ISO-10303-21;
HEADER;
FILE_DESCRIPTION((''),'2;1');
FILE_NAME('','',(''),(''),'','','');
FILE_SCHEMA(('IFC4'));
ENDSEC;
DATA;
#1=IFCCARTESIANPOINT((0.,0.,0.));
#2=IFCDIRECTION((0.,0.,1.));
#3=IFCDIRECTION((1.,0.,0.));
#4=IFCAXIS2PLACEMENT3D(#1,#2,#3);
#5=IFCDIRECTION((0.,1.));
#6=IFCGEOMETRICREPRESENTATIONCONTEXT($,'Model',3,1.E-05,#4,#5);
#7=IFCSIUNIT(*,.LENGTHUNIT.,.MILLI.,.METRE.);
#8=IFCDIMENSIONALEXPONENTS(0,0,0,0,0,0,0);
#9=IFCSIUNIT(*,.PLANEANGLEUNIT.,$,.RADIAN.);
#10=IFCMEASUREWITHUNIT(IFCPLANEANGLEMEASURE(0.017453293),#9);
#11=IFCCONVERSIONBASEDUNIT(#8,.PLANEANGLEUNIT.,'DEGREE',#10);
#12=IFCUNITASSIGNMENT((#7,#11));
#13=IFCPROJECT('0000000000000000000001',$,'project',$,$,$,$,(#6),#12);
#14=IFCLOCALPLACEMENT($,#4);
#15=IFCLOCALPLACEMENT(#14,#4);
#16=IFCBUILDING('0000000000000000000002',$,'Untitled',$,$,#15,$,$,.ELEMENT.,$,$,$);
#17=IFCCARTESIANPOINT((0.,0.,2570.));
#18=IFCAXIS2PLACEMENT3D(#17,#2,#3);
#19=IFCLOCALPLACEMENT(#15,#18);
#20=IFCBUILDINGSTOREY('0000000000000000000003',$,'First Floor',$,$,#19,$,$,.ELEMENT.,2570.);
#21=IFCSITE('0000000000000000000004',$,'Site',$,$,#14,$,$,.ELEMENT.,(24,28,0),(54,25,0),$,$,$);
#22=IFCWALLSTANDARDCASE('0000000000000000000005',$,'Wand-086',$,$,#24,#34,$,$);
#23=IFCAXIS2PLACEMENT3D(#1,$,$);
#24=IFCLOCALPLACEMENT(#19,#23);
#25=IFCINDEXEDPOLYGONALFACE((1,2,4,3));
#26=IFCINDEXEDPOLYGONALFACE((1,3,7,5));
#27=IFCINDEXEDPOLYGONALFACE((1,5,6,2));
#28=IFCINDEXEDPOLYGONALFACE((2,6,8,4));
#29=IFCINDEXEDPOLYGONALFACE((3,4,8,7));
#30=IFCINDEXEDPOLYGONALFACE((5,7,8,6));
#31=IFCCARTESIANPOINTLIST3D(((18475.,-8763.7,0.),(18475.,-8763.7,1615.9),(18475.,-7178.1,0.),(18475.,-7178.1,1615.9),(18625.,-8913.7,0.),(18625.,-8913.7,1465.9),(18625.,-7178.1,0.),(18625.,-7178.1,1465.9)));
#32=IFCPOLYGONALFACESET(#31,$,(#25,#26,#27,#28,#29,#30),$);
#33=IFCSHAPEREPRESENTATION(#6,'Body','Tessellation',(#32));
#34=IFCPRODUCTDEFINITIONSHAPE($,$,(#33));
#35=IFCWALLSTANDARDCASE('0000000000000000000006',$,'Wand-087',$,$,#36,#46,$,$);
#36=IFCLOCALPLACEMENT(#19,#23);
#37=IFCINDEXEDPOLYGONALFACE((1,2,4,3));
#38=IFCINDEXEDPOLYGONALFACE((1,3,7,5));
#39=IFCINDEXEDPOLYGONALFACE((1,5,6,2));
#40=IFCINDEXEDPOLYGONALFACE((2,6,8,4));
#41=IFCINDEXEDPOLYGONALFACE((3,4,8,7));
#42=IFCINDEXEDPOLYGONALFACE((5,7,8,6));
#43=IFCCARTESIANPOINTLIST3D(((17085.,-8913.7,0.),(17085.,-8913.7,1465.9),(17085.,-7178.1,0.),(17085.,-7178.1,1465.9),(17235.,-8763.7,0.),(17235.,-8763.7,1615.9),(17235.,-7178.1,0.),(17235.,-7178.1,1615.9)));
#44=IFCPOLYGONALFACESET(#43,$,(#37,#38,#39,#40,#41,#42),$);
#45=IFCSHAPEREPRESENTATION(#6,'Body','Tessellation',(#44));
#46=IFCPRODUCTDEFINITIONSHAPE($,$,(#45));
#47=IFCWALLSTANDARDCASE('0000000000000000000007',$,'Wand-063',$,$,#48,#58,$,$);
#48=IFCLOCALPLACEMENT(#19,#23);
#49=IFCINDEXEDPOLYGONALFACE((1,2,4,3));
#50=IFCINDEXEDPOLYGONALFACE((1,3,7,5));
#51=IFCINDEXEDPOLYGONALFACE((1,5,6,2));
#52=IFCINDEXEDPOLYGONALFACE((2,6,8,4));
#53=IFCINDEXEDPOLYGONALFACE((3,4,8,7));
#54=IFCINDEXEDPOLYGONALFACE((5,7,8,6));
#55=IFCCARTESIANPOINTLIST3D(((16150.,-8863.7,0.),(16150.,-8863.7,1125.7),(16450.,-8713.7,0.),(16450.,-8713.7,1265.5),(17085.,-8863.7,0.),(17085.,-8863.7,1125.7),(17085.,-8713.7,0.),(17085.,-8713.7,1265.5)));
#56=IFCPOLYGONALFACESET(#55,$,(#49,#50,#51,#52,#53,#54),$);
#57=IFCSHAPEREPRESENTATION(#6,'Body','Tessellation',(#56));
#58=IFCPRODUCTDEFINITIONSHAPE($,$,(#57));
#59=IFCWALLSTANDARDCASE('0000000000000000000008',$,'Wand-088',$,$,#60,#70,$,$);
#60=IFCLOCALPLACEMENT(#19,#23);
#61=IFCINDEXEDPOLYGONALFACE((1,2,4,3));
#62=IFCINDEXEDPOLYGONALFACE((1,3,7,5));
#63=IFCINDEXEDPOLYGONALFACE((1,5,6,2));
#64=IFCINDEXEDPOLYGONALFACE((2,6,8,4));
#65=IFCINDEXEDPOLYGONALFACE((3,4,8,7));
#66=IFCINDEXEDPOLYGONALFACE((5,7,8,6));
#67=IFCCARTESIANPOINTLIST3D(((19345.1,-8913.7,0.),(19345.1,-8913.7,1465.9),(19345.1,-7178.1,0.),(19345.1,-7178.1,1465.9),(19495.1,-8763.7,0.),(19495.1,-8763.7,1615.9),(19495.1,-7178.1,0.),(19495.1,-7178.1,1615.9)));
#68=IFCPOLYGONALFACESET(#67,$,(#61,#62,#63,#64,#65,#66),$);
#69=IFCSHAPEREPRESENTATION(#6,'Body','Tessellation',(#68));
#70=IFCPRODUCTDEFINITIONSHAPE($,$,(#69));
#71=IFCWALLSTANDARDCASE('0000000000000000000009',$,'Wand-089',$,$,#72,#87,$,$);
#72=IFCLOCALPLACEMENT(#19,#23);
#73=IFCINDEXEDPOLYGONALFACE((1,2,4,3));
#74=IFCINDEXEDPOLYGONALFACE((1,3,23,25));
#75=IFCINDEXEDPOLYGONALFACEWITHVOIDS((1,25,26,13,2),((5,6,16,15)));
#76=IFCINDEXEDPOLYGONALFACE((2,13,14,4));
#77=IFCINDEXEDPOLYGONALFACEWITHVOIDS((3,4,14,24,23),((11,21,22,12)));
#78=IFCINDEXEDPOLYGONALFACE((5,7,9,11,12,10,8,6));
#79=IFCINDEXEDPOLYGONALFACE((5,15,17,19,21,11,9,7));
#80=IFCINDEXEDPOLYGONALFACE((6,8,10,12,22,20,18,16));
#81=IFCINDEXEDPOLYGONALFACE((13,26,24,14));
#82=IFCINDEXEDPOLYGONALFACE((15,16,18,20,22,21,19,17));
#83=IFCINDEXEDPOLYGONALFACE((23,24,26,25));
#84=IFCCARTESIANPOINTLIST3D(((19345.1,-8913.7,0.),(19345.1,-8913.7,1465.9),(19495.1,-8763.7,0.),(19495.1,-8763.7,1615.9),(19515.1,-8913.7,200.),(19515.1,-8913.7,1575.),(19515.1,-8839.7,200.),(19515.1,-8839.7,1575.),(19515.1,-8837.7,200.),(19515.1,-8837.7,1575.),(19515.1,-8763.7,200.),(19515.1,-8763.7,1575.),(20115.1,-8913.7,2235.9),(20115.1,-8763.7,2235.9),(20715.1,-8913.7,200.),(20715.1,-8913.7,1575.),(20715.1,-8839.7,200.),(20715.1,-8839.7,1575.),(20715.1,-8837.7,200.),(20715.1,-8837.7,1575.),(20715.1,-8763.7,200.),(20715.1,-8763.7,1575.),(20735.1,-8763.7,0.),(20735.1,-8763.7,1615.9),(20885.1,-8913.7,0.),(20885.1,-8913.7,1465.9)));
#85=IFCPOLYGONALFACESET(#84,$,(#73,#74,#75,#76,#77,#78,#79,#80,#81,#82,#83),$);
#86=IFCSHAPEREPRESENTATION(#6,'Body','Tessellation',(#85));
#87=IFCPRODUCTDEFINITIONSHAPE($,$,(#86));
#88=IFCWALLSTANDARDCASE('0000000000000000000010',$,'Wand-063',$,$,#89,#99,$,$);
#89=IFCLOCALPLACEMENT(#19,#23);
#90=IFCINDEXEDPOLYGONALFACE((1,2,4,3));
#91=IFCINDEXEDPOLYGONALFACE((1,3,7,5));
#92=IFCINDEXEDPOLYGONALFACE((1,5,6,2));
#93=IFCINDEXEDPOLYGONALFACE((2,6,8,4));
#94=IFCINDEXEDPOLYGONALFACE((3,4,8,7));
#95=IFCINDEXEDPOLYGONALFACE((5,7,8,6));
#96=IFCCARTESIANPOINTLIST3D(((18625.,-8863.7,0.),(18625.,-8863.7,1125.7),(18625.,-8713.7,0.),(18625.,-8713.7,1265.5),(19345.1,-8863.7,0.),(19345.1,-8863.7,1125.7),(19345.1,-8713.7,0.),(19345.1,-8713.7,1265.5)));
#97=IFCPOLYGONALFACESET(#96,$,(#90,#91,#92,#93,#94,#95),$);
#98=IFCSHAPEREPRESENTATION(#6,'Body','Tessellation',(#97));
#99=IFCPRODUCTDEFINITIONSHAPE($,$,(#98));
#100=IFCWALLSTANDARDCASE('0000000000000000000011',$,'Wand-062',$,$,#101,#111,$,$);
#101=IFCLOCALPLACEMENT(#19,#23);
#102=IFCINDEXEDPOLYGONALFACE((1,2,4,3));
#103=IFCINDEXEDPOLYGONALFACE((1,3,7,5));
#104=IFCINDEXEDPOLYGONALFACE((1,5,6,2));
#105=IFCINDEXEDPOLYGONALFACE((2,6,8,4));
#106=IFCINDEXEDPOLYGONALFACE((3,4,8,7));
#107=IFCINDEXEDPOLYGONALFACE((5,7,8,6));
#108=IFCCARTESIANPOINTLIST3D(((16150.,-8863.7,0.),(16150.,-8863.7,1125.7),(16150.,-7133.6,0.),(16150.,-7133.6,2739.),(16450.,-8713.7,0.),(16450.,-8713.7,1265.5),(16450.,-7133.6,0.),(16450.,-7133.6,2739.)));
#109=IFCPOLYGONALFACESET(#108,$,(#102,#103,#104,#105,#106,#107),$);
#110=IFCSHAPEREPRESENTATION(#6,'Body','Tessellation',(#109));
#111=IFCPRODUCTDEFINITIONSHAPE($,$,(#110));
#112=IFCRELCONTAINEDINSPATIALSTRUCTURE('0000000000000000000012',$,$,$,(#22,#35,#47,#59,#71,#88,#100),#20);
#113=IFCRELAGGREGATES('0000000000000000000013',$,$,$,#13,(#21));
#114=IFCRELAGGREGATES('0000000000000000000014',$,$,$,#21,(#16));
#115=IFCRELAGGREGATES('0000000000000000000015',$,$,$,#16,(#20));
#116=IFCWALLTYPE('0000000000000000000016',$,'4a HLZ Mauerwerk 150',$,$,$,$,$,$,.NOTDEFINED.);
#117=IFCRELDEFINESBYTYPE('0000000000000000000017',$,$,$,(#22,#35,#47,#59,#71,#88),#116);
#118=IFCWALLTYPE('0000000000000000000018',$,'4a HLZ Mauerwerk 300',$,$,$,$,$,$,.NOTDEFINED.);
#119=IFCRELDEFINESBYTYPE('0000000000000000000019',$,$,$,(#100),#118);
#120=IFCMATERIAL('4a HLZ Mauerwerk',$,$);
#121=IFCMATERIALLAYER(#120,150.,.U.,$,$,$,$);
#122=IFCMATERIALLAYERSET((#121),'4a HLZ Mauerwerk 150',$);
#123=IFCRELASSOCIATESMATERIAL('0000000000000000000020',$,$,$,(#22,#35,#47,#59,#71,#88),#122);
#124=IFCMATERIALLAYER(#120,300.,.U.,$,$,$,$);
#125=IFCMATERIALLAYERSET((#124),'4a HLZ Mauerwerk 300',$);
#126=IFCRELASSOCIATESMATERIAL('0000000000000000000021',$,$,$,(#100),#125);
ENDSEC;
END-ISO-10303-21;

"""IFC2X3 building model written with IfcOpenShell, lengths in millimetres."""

from ifc_helpers import new_model, entity, si_unit, converted_unit, direction, frame, origin_with_axes, origin_2d_with_axis, place, context, project, spatial, polyline, rectangle, outline, extrude, clip, halfspace, bounded_halfspace, material, layer, layer_set, layer_usage, type_object, element, save


model = new_model("IFC2X3")

# Units and contexts
model_context = context("Model", 3, precision=1e-05, world=origin_with_axes(), true_north=direction((0.0, 1.0)))
ifc_project = project(units=[si_unit("LENGTHUNIT", "METRE", prefix="MILLI"), converted_unit("PLANEANGLEUNIT", "DEGREE", entity("IfcPlaneAngleMeasure", 0.017453293), si_unit("PLANEANGLEUNIT", "RADIAN"), dimensions=[0, 0, 0, 0, 0, 0, 0])], contexts=[model_context])

# Site, building, storey
site_placement = place(None, origin_with_axes())
site = spatial("IfcSite", under=ifc_project, at=site_placement, Name="Site", CompositionType="ELEMENT", RefLatitude=(24, 28, 0), RefLongitude=(54, 25, 0))
building_placement = place(site_placement, origin_with_axes())
building = spatial("IfcBuilding", under=site, at=building_placement, Name="Untitled", CompositionType="ELEMENT")
storey_placement = place(building_placement, frame((0.0, 0.0, 2570.0), z_axis=(0.0, 0.0, 1.0), x_axis=(1.0, 0.0, 0.0)))
storey = spatial("IfcBuildingStorey", under=building, at=storey_placement, Name="First Floor", CompositionType="ELEMENT", Elevation=2570.0)

# Shared definitions
ifc_material_1 = material(Name="4a HLZ Mauerwerk")
ifc_layer_1 = layer(ifc_material_1, 150.0, ventilated="UNKNOWN")
ifc_layer_set_1 = layer_set([ifc_layer_1], Name="4a HLZ Mauerwerk 150")
wall_type_1 = type_object("IfcWallType", Name="4a HLZ Mauerwerk 150", PredefinedType="NOTDEFINED")

# Walls
ifc_layer_usage_1 = layer_usage(ifc_layer_set_1, "AXIS2", "POSITIVE", 0.0)
wall_1_placement = place(storey_placement, frame((18625.0, -8913.7, 0.0), z_axis=(0.0, 0.0, 1.0), x_axis=(0.0, 1.0, 0.0)))
element("IfcWallStandardCase", 1, at=wall_1_placement, inside=storey, type_object=wall_type_1, material=ifc_layer_usage_1, Name="Wand-086", context=model_context, shape_type="Clipping", body=[
    clip(extrude(outline(polyline([(0.0, 0.0), (1735.6, 0.0), (1735.6, 150.0), (150.0, 150.0), (0.0, 0.0)])), origin_with_axes(), (0.0, 0.0, 1.0), 5316.0), halfspace(frame((0.0, -733.0, 733.0), z_axis=(0.0, 0.707107, -0.707107), x_axis=(0.0, -0.707107, -0.707107)), True)),
])
ifc_layer_usage_2 = layer_usage(ifc_layer_set_1, "AXIS2", "NEGATIVE", 0.0)
wall_2_placement = place(storey_placement, frame((17085.0, -8913.7, 0.0), z_axis=(0.0, 0.0, 1.0), x_axis=(0.0, 1.0, 0.0)))
element("IfcWallStandardCase", 2, at=wall_2_placement, inside=storey, type_object=wall_type_1, material=ifc_layer_usage_2, Name="Wand-087", context=model_context, shape_type="Clipping", body=[
    clip(extrude(outline(polyline([(150.0, -150.0), (1735.6, -150.0), (1735.6, 0.0), (0.0, 0.0), (150.0, -150.0)])), origin_with_axes(), (0.0, 0.0, 1.0), 5316.0), halfspace(frame((0.0, 733.0, 733.0), z_axis=(0.0, -0.707107, -0.707107), x_axis=(0.0, -0.707107, 0.707107)), True)),
])
ifc_layer_usage_3 = layer_usage(ifc_layer_set_1, "AXIS2", "POSITIVE", 0.0)
wall_3_placement = place(storey_placement, frame((16150.0, -8863.7, 0.0), z_axis=(0.0, 0.0, 1.0), x_axis=(1.0, 0.0, 0.0)))
element("IfcWallStandardCase", 3, at=wall_3_placement, inside=storey, type_object=wall_type_1, material=ifc_layer_usage_3, Name="Wand-063", context=model_context, shape_type="Clipping", body=[
    clip(extrude(outline(polyline([(0.0, 0.0), (935.0, 0.0), (935.0, 150.0), (300.0, 150.0), (0.0, 0.0)])), origin_with_axes(), (0.0, 0.0, 1.0), 5316.0), halfspace(frame((0.0, -561.5, 602.1), z_axis=(0.0, 0.681998, -0.731354), x_axis=(0.0, -0.731354, -0.681998)), True)),
])
ifc_layer_usage_4 = layer_usage(ifc_layer_set_1, "AXIS2", "NEGATIVE", 0.0)
wall_4_placement = place(storey_placement, frame((19345.1, -8913.7, 0.0), z_axis=(0.0, 0.0, 1.0), x_axis=(0.0, 1.0, 0.0)))
element("IfcWallStandardCase", 4, at=wall_4_placement, inside=storey, type_object=wall_type_1, material=ifc_layer_usage_4, Name="Wand-088", context=model_context, shape_type="Clipping", body=[
    clip(extrude(outline(polyline([(150.0, -150.0), (1735.6, -150.0), (1735.6, 0.0), (0.0, 0.0), (150.0, -150.0)])), origin_with_axes(), (0.0, 0.0, 1.0), 5316.0), halfspace(frame((0.0, 733.0, 733.0), z_axis=(0.0, -0.707107, -0.707107), x_axis=(0.0, -0.707107, 0.707107)), True)),
])

# Wall, opening
ifc_layer_usage_5 = layer_usage(ifc_layer_set_1, "AXIS2", "POSITIVE", 0.0)
wall_5_placement = place(storey_placement, frame((19345.1, -8913.7, 0.0), z_axis=(0.0, 0.0, 1.0), x_axis=(1.0, 0.0, 0.0)))
wall_5 = element("IfcWallStandardCase", 5, at=wall_5_placement, inside=storey, type_object=wall_type_1, material=ifc_layer_usage_5, Name="Wand-089", context=model_context, shape_type="Clipping", body=[
    clip(clip(extrude(outline(polyline([(0.0, 0.0), (1540.0, 0.0), (1390.0, 150.0), (150.0, 150.0), (0.0, 0.0)])), origin_with_axes(), (0.0, 0.0, 1.0), 5316.0), bounded_halfspace(frame((-733.0, 0.0, 733.0), z_axis=(0.707107, 0.0, -0.707107), x_axis=(0.707107, 0.0, 0.707107)), True, origin_with_axes(), polyline([(0.0, 0.0), (770.0, 0.0), (770.0, 150.0), (0.0, 150.0), (0.0, 0.0)]))), bounded_halfspace(frame((1503.0, 0.0, 1503.0), z_axis=(-0.707107, 0.0, -0.707107), x_axis=(0.707107, 0.0, -0.707107)), True, origin_with_axes(), polyline([(770.0, 0.0), (1540.0, 0.0), (1540.0, 150.0), (770.0, 150.0), (770.0, 0.0)]))),
])
opening_1_placement = place(wall_5_placement, frame((770.0, 0.0, 200.0), z_axis=(0.0, 0.0, 1.0), x_axis=(1.0, 0.0, 0.0)))
element("IfcOpeningElement", 6, at=opening_1_placement, cuts=wall_5, context=model_context, shape_type="SweptSolid", body=[
    extrude(rectangle(XDim=1200.0, YDim=1375.0, at=origin_2d_with_axis()), frame((0.0, -226.0, 687.5), z_axis=(0.0, 1.0, 0.0), x_axis=(1.0, 0.0, 0.0)), (0.0, 0.0, 1.0), 302.0),
    extrude(rectangle(XDim=1200.0, YDim=1375.0, at=origin_2d_with_axis()), frame((0.0, 376.0, 687.5), z_axis=(0.0, -1.0, 0.0), x_axis=(1.0, 0.0, 0.0)), (0.0, 0.0, 1.0), 302.0),
])

# Walls
ifc_layer_usage_6 = layer_usage(ifc_layer_set_1, "AXIS2", "POSITIVE", 0.0)
wall_6_placement = place(storey_placement, frame((18625.0, -8863.7, 0.0), z_axis=(0.0, 0.0, 1.0), x_axis=(1.0, 0.0, 0.0)))
element("IfcWallStandardCase", 7, at=wall_6_placement, inside=storey, type_object=wall_type_1, material=ifc_layer_usage_6, Name="Wand-063", context=model_context, shape_type="Clipping", body=[
    clip(extrude(outline(polyline([(0.0, 0.0), (720.0, 0.0), (720.0, 150.0), (0.0, 150.0), (0.0, 0.0)])), origin_with_axes(), (0.0, 0.0, 1.0), 5316.0), bounded_halfspace(frame((0.0, -561.5, 602.1), z_axis=(0.0, 0.681998, -0.731354), x_axis=(0.0, -0.731354, -0.681998)), True, origin_with_axes(), polyline([(0.0, 0.0), (720.0, 0.0), (720.0, 150.0), (0.0, 150.0), (0.0, 0.0)]))),
])
ifc_layer_2 = layer(ifc_material_1, 300.0, ventilated="UNKNOWN")
ifc_layer_set_2 = layer_set([ifc_layer_2], Name="4a HLZ Mauerwerk 300")
ifc_layer_usage_7 = layer_usage(ifc_layer_set_2, "AXIS2", "POSITIVE", 0.0)
wall_type_2 = type_object("IfcWallType", Name="4a HLZ Mauerwerk 300", PredefinedType="NOTDEFINED")
wall_7_placement = place(storey_placement, frame((16150.0, -7133.6, 0.0), z_axis=(0.0, 0.0, 1.0), x_axis=(0.0, -1.0, 0.0)))
element("IfcWallStandardCase", 8, at=wall_7_placement, inside=storey, type_object=wall_type_2, material=ifc_layer_usage_7, Name="Wand-062", context=model_context, shape_type="Clipping", body=[
    clip(extrude(outline(polyline([(0.0, 0.0), (1730.0, 0.0), (1580.0, 300.0), (0.0, 300.0), (0.0, 0.0)])), origin_with_axes(), (0.0, 0.0, 1.0), 5316.0), bounded_halfspace(frame((1366.1, 0.0, 1465.0), z_axis=(-0.681998, 0.0, -0.731354), x_axis=(0.731354, 0.0, -0.681998)), True, origin_with_axes(), polyline([(0.0, 0.0), (1730.0, 0.0), (1730.0, 300.0), (0.0, 300.0), (0.0, 0.0)]))),
])

save(model, "model.ifc")
